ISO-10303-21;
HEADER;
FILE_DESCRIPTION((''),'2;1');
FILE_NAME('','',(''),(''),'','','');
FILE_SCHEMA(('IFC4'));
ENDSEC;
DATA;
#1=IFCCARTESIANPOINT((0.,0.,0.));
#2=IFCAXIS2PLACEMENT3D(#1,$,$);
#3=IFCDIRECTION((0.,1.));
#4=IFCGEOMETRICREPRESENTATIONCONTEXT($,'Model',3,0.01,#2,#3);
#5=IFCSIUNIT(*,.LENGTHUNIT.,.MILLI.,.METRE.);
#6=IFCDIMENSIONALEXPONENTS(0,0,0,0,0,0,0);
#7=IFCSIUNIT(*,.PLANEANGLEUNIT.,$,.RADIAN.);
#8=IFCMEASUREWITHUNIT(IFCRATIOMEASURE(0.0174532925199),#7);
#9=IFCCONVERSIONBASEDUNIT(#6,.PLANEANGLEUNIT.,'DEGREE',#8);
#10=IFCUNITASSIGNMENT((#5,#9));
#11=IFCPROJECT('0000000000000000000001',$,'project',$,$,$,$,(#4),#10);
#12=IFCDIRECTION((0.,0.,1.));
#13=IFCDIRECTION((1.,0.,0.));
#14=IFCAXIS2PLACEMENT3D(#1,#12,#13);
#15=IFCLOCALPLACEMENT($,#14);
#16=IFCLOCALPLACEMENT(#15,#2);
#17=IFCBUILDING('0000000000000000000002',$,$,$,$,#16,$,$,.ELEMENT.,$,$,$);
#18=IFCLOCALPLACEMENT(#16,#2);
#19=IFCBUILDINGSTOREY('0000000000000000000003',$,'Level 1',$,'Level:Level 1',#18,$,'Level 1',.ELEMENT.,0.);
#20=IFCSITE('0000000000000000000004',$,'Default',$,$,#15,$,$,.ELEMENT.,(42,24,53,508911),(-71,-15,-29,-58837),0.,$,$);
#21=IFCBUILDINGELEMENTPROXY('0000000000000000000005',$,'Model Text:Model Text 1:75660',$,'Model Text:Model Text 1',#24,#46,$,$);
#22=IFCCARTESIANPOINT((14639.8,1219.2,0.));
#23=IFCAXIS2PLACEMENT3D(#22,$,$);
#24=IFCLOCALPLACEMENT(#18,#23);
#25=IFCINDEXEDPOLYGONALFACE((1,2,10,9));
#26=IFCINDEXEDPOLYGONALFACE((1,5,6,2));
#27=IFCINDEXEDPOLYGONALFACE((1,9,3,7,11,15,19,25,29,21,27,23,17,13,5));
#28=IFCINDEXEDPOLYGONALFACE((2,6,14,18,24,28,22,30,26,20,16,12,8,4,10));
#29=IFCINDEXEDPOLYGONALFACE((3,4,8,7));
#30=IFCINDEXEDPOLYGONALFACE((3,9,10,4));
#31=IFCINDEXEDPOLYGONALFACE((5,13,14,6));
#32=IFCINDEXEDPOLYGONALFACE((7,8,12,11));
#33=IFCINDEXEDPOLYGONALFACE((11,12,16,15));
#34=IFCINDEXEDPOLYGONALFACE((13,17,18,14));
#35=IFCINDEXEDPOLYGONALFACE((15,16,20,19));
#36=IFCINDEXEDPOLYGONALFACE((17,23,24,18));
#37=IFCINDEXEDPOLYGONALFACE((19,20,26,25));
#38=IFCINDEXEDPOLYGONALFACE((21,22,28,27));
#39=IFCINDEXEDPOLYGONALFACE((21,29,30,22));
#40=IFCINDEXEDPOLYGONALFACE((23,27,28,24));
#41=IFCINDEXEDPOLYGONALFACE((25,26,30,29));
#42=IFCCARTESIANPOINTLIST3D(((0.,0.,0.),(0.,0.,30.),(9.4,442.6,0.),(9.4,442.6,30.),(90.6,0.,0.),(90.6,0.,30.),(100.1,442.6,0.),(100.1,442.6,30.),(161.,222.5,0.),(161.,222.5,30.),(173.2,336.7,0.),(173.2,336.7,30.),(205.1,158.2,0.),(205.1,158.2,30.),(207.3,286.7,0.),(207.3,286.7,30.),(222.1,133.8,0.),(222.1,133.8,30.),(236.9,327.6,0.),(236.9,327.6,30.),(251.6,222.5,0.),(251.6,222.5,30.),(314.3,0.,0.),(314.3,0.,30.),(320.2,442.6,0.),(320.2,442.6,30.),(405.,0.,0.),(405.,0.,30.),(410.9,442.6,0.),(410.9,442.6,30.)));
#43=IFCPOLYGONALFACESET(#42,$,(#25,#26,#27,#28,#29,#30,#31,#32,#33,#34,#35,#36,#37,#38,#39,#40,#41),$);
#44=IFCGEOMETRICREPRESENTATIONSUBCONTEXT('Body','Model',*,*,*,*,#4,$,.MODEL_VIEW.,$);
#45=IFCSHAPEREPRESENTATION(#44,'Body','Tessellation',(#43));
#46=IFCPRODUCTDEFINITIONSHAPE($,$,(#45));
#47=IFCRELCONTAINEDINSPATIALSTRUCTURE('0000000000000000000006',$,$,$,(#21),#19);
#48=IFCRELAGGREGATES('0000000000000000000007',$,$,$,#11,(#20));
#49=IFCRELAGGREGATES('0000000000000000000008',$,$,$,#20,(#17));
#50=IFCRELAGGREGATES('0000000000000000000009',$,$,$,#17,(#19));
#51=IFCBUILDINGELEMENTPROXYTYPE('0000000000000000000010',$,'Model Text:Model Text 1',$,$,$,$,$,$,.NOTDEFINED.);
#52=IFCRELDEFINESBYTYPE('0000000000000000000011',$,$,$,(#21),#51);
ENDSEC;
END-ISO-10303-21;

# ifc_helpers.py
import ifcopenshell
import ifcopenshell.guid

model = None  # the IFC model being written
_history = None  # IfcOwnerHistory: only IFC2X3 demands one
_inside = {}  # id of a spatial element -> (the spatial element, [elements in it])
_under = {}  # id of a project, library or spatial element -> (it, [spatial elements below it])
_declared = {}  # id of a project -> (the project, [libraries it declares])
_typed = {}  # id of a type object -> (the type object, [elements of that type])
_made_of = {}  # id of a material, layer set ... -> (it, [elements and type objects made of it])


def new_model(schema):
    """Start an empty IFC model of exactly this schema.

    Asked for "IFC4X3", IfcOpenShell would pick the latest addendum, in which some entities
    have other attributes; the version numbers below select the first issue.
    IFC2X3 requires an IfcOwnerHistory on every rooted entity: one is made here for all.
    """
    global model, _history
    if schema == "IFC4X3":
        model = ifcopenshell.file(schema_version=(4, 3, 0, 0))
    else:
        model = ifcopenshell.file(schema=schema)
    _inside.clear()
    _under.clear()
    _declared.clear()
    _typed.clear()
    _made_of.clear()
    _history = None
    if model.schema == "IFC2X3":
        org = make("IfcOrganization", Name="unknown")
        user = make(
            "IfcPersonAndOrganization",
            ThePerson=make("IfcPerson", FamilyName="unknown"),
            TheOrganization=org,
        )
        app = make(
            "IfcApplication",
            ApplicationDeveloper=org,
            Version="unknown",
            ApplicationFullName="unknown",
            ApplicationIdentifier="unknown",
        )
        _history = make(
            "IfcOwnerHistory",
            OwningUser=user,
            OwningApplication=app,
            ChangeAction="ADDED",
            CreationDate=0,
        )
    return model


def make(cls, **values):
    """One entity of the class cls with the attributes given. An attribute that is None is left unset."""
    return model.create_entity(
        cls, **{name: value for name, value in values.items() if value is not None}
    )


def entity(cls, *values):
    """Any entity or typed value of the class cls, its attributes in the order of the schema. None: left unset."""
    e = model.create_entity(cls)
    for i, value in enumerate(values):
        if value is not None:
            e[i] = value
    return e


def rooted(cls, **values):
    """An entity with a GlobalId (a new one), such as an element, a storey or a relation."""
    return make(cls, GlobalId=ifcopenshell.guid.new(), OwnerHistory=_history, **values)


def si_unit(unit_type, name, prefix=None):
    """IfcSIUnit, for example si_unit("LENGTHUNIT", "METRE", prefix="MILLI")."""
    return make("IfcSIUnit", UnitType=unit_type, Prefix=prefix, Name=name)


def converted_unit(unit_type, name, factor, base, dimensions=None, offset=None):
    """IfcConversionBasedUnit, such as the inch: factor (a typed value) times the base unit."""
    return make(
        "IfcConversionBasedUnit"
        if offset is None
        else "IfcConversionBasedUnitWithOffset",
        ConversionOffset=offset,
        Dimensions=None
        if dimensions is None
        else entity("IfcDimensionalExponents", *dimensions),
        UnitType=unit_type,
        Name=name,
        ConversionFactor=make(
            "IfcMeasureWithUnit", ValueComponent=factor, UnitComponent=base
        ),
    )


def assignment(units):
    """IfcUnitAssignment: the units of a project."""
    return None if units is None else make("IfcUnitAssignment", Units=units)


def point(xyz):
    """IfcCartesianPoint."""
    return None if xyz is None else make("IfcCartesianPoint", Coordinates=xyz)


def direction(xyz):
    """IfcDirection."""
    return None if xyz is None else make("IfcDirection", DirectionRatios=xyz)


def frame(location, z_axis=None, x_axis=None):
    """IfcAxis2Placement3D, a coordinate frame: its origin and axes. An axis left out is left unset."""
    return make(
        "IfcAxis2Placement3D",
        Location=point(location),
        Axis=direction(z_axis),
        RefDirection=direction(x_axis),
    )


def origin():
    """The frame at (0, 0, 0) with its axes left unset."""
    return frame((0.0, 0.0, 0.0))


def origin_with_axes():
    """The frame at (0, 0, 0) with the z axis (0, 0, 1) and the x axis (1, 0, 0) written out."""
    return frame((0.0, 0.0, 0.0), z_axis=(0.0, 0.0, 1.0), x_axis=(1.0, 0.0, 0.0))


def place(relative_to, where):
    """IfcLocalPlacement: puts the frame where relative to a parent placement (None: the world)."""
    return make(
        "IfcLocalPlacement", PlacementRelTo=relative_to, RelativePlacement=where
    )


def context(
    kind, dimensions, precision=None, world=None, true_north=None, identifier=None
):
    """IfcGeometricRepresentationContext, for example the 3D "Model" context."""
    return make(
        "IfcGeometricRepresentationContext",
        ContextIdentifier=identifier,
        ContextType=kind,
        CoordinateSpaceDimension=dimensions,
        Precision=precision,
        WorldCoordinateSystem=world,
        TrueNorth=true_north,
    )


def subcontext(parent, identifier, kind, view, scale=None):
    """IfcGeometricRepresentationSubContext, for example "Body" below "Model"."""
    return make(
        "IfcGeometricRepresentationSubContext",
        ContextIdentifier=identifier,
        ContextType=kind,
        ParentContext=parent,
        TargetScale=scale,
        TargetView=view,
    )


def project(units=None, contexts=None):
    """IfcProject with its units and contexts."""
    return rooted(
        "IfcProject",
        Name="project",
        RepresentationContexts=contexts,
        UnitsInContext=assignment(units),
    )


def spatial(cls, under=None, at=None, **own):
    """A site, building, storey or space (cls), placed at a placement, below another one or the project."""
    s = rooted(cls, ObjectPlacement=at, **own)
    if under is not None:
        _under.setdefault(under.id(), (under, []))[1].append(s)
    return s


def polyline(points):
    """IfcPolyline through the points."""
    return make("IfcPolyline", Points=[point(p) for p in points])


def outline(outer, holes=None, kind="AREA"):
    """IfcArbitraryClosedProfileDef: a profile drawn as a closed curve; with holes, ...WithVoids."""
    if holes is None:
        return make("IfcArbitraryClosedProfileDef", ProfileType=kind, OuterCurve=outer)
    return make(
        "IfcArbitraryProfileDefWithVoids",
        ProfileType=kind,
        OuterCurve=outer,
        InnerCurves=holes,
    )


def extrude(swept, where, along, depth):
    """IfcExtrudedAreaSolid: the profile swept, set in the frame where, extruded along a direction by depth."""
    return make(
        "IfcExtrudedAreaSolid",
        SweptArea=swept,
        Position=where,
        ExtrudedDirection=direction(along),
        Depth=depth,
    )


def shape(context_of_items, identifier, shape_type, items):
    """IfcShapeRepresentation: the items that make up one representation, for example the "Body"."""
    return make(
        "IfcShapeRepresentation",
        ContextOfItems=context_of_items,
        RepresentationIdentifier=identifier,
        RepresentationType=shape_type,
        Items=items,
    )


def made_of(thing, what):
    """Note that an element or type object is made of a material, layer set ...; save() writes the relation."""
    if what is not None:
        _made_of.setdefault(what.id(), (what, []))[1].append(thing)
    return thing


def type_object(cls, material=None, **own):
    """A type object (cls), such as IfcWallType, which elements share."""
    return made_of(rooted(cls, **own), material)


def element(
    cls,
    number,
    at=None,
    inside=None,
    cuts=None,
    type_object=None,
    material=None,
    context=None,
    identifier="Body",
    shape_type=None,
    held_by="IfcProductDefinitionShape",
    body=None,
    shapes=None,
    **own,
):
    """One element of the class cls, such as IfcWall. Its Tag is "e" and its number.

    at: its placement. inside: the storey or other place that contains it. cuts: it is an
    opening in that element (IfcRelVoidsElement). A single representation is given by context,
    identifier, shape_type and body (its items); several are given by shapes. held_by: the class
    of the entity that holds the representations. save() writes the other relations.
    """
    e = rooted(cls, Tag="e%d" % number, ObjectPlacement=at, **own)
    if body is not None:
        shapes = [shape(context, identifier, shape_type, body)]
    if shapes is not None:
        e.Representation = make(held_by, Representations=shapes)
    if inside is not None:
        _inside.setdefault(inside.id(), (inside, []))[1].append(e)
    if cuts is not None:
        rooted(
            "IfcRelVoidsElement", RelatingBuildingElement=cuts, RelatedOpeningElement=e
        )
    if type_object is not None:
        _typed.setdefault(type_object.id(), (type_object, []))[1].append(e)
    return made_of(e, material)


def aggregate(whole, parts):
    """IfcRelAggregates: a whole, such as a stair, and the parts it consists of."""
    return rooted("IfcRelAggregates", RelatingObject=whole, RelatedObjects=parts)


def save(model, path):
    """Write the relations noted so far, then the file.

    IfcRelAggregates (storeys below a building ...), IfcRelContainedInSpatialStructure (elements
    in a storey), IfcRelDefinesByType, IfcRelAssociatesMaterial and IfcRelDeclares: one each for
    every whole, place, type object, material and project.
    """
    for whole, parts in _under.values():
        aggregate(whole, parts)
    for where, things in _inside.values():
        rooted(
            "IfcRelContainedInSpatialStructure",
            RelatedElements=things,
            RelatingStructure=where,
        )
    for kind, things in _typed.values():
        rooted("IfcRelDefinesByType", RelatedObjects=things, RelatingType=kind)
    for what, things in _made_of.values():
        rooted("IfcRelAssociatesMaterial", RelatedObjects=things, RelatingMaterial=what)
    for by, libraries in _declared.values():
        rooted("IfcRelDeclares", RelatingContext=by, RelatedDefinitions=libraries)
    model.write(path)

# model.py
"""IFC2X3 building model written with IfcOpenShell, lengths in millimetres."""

from ifc_helpers import new_model, entity, si_unit, converted_unit, direction, frame, origin, origin_with_axes, place, context, subcontext, project, spatial, polyline, outline, extrude, type_object, element, save


model = new_model("IFC2X3")

# Units and contexts
model_context = context("Model", 3, precision=0.01, world=origin(), true_north=direction((0.0, 1.0)))
body_context = subcontext(model_context, "Body", "Model", "MODEL_VIEW")
ifc_project = project(units=[si_unit("LENGTHUNIT", "METRE", prefix="MILLI"), converted_unit("PLANEANGLEUNIT", "DEGREE", entity("IfcRatioMeasure", 0.0174532925199), si_unit("PLANEANGLEUNIT", "RADIAN"), dimensions=[0, 0, 0, 0, 0, 0, 0])], contexts=[model_context])

# Site, building, storey
site_placement = place(None, origin_with_axes())
site = spatial("IfcSite", under=ifc_project, at=site_placement, Name="Default", CompositionType="ELEMENT", RefLatitude=(42, 24, 53, 508911), RefLongitude=(-71, -15, -29, -58837), RefElevation=0.0)
building_placement = place(site_placement, origin())
building = spatial("IfcBuilding", under=site, at=building_placement, CompositionType="ELEMENT")
storey_placement = place(building_placement, origin())
storey = spatial("IfcBuildingStorey", under=building, at=storey_placement, Name="Level 1", ObjectType="Level:Level 1", LongName="Level 1", CompositionType="ELEMENT", Elevation=0.0)

# Building element proxy
building_element_proxy_type_1 = type_object("IfcBuildingElementProxyType", Name="Model Text:Model Text 1", PredefinedType="NOTDEFINED")
proxy_1_placement = place(storey_placement, frame((14639.8, 1219.2, 0.0)))
element("IfcBuildingElementProxy", 1, at=proxy_1_placement, inside=storey, type_object=building_element_proxy_type_1, Name="Model Text:Model Text 1:75660", ObjectType="Model Text:Model Text 1", context=body_context, shape_type="SweptSolid", body=[
    extrude(outline(polyline([(-207.2, -230.6), (-116.5, -230.6), (-2.1, -72.4), (14.9, -96.8), (107.1, -230.6), (197.8, -230.6), (44.4, -8.1), (203.7, 212.1), (113.0, 212.1), (29.7, 97.0), (0.2, 56.1), (-34.0, 106.1), (-107.1, 212.1), (-197.8, 212.1), (-46.2, -8.1), (-207.2, -230.6)])), frame((207.2, 230.6, 0.0)), (0.0, 0.0, 1.0), 30.0),
])

save(model, "model.ifc")
